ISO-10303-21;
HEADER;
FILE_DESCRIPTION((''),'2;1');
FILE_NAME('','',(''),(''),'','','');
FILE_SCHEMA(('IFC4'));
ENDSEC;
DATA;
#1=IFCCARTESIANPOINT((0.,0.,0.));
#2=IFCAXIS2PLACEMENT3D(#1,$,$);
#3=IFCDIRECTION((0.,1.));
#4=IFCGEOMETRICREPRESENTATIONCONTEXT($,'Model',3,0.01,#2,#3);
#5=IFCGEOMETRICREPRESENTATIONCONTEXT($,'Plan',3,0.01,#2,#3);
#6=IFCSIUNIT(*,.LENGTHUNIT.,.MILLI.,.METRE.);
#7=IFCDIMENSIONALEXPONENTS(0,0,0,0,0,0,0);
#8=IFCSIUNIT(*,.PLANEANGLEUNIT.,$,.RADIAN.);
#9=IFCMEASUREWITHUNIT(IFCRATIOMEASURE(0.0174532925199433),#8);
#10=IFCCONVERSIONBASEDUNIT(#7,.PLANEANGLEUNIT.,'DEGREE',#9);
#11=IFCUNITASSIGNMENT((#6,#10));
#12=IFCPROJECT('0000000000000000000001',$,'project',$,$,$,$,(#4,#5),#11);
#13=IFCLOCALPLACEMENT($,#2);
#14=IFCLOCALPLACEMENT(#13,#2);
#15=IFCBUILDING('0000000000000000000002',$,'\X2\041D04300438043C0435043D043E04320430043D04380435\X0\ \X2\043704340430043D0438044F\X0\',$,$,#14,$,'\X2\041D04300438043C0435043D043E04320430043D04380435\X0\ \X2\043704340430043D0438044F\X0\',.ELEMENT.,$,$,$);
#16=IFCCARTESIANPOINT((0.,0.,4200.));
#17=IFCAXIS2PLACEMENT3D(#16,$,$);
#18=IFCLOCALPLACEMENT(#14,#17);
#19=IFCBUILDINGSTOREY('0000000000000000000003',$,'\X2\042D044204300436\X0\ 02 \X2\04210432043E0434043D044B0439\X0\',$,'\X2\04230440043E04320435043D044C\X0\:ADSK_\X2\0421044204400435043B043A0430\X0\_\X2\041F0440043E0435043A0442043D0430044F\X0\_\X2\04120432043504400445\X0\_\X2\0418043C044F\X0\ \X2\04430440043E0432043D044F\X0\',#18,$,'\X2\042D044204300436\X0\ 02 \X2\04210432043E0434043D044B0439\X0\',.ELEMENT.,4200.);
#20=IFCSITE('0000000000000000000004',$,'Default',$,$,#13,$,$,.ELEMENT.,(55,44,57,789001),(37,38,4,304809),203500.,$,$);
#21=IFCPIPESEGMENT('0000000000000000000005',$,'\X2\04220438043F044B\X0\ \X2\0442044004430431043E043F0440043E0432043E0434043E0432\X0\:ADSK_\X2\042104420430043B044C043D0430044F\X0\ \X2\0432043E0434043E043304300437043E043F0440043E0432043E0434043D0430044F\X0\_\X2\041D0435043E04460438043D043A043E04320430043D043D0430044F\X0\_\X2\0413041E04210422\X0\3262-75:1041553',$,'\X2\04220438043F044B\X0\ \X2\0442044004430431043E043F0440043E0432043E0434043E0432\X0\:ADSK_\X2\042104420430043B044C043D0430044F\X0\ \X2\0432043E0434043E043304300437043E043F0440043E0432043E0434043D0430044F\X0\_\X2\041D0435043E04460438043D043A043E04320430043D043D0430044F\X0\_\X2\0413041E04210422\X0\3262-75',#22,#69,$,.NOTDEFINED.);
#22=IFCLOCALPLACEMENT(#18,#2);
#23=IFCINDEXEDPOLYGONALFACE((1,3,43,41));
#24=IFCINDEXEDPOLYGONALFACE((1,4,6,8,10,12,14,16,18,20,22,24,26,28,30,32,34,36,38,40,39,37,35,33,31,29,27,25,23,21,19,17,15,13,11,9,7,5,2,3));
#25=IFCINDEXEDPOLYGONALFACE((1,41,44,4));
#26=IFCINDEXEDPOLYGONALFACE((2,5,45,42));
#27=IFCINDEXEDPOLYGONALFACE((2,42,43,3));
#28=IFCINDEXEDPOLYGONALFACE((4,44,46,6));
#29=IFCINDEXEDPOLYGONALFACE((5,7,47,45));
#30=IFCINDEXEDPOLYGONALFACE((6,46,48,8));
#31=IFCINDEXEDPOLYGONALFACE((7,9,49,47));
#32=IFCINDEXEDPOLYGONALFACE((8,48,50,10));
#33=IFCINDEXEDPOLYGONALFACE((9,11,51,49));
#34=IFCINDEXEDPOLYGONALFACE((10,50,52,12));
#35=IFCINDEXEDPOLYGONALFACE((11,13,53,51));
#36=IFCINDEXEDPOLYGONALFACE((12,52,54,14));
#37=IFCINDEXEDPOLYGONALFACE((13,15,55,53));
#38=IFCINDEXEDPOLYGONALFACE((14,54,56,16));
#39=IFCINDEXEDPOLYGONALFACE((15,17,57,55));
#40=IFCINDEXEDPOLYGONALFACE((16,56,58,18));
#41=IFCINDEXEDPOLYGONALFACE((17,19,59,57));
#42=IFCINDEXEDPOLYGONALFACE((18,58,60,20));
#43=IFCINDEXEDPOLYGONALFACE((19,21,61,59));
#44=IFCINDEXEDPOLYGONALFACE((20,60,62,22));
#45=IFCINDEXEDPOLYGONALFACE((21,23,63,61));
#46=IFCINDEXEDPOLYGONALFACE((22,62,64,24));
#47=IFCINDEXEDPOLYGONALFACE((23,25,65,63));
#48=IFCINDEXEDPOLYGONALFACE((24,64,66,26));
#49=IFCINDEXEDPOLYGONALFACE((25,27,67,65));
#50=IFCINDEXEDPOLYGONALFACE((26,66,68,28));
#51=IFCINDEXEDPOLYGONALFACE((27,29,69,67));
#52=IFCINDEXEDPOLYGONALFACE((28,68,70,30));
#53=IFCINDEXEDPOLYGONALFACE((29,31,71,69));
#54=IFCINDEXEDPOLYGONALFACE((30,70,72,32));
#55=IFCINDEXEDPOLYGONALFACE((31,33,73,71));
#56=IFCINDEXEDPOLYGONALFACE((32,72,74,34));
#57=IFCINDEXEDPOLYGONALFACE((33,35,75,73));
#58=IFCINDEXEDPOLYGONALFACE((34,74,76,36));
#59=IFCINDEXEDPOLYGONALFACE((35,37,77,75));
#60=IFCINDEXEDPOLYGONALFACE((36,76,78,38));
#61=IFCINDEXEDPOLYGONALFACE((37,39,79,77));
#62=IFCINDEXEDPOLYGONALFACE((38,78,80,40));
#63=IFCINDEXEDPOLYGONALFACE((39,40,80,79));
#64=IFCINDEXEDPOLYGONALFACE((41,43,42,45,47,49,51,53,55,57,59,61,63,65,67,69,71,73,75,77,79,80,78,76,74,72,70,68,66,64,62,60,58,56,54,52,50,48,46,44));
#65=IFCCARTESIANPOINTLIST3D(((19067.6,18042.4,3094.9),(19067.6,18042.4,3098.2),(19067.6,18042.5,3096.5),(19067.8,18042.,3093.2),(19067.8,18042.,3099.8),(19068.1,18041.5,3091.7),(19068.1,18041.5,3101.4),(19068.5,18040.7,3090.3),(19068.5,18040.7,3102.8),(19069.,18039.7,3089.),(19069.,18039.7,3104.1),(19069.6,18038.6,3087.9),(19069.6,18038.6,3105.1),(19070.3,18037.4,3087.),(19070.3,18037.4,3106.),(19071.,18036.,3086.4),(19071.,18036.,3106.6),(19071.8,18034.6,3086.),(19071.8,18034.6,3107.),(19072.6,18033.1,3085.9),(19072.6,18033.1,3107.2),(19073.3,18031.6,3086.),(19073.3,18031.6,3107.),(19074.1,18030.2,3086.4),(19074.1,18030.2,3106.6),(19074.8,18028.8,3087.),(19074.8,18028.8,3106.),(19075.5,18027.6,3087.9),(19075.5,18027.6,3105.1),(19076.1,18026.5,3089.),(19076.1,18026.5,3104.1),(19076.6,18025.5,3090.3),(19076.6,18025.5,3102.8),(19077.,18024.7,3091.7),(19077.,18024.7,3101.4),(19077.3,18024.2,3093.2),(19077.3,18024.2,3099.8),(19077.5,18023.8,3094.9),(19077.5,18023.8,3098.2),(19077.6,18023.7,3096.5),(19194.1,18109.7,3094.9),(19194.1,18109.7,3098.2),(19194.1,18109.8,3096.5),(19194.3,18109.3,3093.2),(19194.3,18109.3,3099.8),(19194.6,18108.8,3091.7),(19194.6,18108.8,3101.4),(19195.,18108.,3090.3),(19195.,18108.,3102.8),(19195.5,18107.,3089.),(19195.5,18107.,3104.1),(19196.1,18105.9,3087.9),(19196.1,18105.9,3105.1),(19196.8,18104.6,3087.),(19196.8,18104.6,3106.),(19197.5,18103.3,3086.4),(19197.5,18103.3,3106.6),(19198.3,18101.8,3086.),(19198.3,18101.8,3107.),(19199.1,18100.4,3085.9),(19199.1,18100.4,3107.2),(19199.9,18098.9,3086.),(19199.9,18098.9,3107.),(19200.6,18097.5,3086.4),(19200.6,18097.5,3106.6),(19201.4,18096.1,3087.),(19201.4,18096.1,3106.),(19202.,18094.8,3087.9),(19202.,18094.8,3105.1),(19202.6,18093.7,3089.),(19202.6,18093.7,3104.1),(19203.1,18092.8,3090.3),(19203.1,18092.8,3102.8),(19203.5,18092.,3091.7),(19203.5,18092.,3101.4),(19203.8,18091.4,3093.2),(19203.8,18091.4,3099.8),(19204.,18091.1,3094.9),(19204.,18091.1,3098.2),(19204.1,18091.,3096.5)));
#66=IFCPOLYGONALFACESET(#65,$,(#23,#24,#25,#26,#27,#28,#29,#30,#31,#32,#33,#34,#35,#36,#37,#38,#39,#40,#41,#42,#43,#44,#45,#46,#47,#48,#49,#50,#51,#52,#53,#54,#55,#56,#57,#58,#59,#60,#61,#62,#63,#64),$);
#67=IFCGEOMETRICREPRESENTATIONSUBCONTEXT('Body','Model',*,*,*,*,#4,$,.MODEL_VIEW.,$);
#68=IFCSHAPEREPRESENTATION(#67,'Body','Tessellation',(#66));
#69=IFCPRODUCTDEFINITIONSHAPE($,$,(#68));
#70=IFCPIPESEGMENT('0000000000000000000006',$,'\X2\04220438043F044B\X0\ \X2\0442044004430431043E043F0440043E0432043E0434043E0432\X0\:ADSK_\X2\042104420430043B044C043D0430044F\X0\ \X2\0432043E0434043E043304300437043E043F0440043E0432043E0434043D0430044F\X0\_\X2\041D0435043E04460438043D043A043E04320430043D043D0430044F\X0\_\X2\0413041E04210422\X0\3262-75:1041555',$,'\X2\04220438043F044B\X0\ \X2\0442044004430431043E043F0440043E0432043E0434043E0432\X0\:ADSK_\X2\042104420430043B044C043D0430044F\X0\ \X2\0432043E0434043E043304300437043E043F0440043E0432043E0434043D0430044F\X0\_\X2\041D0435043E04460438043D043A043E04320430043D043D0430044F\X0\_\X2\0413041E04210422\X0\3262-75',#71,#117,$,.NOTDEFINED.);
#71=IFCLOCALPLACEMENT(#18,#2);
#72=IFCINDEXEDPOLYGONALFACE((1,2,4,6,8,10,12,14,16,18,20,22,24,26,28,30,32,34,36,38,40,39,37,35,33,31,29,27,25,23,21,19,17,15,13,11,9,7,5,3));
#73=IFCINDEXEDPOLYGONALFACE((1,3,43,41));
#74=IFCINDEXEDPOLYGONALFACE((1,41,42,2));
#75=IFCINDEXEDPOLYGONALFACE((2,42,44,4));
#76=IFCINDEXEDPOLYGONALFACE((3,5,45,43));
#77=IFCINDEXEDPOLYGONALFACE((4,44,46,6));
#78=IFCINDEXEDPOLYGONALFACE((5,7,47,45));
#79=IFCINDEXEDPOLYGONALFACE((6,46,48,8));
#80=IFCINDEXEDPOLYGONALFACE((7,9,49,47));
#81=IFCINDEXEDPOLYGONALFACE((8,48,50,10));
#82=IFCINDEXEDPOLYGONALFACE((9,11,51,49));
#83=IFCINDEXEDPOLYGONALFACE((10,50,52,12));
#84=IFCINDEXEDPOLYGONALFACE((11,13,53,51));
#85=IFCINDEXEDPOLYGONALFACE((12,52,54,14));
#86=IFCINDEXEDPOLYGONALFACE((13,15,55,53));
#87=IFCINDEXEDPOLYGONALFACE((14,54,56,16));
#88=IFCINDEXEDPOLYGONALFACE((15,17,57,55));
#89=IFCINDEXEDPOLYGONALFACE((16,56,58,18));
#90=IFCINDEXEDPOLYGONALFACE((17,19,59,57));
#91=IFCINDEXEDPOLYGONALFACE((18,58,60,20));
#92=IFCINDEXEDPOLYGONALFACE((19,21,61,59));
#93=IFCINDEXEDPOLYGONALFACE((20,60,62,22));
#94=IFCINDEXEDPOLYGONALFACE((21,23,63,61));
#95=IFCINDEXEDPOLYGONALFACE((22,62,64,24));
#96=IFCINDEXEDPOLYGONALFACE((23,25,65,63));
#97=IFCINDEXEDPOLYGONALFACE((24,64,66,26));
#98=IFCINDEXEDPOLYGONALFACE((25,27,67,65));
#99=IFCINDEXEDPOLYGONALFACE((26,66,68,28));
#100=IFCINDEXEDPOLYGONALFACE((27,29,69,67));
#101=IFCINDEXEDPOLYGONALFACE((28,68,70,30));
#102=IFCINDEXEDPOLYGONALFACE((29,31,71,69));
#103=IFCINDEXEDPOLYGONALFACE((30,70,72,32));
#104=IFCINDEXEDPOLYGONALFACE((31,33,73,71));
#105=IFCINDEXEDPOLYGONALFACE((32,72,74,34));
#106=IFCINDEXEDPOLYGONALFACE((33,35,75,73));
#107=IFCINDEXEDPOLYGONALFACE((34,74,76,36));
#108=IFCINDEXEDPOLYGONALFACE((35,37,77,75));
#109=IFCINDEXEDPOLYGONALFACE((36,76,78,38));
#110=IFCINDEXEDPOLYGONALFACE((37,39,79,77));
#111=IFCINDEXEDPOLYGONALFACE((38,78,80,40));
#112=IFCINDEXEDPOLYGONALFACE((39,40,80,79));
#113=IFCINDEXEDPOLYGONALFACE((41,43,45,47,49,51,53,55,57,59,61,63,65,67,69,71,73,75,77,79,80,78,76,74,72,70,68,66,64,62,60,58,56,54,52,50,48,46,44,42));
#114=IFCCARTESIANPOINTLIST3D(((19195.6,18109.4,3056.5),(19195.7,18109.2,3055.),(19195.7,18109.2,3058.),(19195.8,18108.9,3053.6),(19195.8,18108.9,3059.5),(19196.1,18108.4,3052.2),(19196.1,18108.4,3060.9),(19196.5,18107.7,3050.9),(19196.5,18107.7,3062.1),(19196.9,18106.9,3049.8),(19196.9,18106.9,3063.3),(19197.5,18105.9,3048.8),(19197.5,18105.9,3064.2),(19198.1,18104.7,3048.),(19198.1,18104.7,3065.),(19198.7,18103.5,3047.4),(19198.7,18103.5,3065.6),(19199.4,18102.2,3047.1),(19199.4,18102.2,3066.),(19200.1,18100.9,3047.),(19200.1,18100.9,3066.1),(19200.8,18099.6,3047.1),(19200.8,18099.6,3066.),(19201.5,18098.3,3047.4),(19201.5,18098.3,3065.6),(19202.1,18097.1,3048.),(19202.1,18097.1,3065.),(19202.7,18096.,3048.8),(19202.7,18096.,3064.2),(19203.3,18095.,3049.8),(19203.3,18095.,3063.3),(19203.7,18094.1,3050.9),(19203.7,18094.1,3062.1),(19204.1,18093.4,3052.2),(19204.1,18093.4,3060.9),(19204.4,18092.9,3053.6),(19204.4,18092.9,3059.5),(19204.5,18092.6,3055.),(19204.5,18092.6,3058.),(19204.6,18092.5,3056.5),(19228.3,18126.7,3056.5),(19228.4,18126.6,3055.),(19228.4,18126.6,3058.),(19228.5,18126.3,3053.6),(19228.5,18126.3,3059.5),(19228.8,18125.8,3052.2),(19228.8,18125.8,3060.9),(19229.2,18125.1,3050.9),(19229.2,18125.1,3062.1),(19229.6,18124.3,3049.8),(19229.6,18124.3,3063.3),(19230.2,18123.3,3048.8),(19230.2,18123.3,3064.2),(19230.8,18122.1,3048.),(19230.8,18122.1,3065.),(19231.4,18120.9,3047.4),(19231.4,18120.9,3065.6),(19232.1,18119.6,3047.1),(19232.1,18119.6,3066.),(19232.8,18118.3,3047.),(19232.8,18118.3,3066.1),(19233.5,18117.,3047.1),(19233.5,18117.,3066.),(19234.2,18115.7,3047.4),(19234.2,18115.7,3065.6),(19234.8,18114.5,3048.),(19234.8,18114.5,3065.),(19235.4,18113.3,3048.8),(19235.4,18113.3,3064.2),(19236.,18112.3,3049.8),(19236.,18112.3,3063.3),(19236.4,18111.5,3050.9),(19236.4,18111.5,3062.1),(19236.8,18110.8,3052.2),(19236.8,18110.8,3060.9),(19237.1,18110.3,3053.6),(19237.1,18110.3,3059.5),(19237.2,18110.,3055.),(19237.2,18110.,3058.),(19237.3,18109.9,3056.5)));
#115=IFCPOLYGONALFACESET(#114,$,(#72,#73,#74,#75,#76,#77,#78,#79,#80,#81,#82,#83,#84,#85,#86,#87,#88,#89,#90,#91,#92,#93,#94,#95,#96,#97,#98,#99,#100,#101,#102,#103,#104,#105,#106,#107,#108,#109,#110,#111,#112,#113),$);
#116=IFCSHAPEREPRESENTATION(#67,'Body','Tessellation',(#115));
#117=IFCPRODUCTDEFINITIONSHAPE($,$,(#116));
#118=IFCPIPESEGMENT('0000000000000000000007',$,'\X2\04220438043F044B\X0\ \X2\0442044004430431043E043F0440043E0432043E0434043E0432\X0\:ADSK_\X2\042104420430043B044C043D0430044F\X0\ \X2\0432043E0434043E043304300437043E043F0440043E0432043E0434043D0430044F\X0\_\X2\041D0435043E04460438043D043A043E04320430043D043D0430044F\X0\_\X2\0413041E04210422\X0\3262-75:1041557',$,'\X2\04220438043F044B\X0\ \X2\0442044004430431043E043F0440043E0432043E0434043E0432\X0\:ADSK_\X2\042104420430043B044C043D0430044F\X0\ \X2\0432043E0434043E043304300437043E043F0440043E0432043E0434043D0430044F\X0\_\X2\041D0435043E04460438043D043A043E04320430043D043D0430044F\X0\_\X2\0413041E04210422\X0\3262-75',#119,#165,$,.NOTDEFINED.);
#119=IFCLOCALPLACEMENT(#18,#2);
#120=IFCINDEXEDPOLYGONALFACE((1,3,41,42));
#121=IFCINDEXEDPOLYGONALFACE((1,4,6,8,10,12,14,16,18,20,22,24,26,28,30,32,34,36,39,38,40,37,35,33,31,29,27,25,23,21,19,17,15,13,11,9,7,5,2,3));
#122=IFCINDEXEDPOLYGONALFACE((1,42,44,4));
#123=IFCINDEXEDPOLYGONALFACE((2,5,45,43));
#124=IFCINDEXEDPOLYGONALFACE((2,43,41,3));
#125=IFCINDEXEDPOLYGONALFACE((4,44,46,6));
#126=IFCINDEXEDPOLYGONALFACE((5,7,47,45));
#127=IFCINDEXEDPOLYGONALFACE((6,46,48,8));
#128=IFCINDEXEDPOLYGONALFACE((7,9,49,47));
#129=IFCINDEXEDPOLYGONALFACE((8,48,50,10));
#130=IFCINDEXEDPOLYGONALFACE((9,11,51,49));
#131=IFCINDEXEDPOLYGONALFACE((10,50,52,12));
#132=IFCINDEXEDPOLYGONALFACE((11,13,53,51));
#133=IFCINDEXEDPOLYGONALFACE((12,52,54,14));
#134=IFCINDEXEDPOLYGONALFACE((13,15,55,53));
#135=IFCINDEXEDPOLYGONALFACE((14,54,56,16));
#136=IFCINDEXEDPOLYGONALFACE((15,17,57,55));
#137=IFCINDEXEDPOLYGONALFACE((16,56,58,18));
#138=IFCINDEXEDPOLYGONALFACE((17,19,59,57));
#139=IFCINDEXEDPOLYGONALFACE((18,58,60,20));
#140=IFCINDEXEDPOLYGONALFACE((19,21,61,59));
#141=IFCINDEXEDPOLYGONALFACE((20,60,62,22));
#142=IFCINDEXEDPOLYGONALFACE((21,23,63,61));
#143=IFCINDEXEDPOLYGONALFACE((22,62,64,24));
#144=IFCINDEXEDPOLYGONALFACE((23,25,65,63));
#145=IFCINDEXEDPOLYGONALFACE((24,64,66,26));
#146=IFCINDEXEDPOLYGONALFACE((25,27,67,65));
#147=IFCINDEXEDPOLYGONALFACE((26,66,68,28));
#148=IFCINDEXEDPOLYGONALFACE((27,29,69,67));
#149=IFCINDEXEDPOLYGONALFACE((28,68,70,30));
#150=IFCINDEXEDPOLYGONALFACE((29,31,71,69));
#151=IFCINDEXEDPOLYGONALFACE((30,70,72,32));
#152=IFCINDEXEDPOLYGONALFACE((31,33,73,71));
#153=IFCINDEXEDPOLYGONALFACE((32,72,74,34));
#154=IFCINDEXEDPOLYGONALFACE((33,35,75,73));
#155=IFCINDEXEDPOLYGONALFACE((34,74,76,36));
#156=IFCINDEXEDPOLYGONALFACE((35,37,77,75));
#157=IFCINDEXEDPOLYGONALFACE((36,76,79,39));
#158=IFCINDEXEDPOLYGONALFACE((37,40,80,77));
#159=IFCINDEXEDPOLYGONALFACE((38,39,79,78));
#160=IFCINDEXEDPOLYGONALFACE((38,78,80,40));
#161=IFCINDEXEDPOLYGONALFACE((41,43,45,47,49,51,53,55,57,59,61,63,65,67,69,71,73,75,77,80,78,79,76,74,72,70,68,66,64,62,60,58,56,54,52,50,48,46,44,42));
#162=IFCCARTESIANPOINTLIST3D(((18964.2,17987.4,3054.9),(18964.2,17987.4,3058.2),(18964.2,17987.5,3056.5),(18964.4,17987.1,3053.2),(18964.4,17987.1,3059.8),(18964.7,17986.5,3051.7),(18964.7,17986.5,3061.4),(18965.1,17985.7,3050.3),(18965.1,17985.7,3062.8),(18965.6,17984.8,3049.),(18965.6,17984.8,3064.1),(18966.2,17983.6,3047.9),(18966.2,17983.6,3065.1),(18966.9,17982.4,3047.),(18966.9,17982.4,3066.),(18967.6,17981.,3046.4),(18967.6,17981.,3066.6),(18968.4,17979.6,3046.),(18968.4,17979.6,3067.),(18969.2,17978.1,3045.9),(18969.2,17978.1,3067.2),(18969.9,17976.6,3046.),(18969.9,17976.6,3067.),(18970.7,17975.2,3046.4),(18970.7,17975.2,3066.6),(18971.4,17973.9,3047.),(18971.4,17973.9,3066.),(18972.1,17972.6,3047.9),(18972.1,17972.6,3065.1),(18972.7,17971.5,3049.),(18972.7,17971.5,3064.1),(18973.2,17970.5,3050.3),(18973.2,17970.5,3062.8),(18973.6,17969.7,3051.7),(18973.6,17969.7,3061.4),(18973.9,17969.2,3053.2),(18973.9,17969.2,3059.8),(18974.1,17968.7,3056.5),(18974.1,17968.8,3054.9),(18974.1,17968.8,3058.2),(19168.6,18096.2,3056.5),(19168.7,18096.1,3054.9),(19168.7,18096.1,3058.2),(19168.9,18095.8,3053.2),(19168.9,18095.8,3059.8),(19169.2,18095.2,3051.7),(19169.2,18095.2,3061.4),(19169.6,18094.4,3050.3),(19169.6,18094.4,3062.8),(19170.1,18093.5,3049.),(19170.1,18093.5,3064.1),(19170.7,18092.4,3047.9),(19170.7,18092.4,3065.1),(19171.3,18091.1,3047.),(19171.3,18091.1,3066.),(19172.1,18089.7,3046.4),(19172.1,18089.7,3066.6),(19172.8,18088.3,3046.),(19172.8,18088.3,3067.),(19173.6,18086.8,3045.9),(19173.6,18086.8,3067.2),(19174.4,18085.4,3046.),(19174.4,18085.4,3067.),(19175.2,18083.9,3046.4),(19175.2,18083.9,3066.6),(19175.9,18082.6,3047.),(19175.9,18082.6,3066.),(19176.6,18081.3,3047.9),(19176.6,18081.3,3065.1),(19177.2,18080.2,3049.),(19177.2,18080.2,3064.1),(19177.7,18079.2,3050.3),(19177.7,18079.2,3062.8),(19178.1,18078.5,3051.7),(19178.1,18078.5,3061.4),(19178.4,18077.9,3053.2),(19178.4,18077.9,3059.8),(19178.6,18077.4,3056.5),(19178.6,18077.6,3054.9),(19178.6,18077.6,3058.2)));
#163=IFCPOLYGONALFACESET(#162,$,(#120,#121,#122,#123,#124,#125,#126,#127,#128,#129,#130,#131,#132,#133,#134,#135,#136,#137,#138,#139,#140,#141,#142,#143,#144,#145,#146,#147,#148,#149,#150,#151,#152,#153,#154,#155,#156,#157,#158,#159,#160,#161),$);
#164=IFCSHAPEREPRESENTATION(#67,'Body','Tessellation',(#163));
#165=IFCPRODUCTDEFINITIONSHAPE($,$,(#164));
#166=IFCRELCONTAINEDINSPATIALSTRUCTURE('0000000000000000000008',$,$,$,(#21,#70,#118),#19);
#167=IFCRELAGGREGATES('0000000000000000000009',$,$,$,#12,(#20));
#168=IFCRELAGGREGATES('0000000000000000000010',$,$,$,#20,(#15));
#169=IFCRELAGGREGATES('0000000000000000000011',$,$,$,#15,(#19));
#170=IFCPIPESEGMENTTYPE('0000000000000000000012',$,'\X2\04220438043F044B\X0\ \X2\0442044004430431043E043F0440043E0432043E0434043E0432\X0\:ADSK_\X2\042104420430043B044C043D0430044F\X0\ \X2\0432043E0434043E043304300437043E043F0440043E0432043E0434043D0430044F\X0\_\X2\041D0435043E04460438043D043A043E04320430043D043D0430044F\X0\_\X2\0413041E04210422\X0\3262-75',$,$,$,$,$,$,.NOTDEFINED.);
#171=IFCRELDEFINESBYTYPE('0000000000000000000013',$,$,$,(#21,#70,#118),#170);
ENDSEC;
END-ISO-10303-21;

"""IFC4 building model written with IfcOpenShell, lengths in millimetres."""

from ifc_helpers import new_model, entity, si_unit, converted_unit, direction, frame, origin, place, context, subcontext, project, spatial, indexed_curve, outline, extrude, type_object, element, save


model = new_model("IFC4")

# Units and contexts
model_context = context("Model", 3, precision=0.01, world=origin(), true_north=direction((0.0, 1.0)))
plan_context = context("Plan", 3, precision=0.01, world=origin(), true_north=direction((0.0, 1.0)))
body_context = subcontext(model_context, "Body", "Model", "MODEL_VIEW")
ifc_project = project(units=[si_unit("LENGTHUNIT", "METRE", prefix="MILLI"), converted_unit("PLANEANGLEUNIT", "DEGREE", entity("IfcRatioMeasure", 0.0174532925199433), si_unit("PLANEANGLEUNIT", "RADIAN"), dimensions=[0, 0, 0, 0, 0, 0, 0])], contexts=[model_context, plan_context])

# Site, building, storey
site_placement = place(None, origin())
site = spatial("IfcSite", under=ifc_project, at=site_placement, Name="Default", CompositionType="ELEMENT", RefLatitude=(55, 44, 57, 789001), RefLongitude=(37, 38, 4, 304809), RefElevation=203500.0)
building_placement = place(site_placement, origin())
building = spatial("IfcBuilding", under=site, at=building_placement, Name="Наименование здания", LongName="Наименование здания", CompositionType="ELEMENT")
storey_placement = place(building_placement, frame((0.0, 0.0, 4200.0)))
storey = spatial("IfcBuildingStorey", under=building, at=storey_placement, Name="Этаж 02 Сводный", ObjectType="Уровень:ADSK_Стрелка_Проектная_Вверх_Имя уровня", LongName="Этаж 02 Сводный", CompositionType="ELEMENT", Elevation=4200.0)

# Pipe segments
pipe_segment_type = type_object("IfcPipeSegmentType", Name="Типы трубопроводов:ADSK_Стальная водогазопроводная_Неоцинкованная_ГОСТ3262-75", PredefinedType="NOTDEFINED")
placement = place(storey_placement, origin())
element("IfcPipeSegment", 1, at=placement, inside=storey, type_object=pipe_segment_type, Name="Типы трубопроводов:ADSK_Стальная водогазопроводная_Неоцинкованная_ГОСТ3262-75:1041553", ObjectType="Типы трубопроводов:ADSK_Стальная водогазопроводная_Неоцинкованная_ГОСТ3262-75", PredefinedType="NOTDEFINED", context=body_context, shape_type="SweptSolid", body=[
    extrude(outline(indexed_curve([(10.6, 0.0), (10.5, 1.7), (10.1, 3.3), (9.5, 4.8), (8.6, 6.3), (7.5, 7.5), (6.3, 8.6), (4.8, 9.5), (3.3, 10.1), (1.7, 10.5), (0.0, 10.6), (-1.7, 10.5), (-3.3, 10.1), (-4.8, 9.5), (-6.3, 8.6), (-7.5, 7.5), (-8.6, 6.3), (-9.5, 4.8), (-10.1, 3.3), (-10.5, 1.7), (-10.6, 0.0), (-10.5, -1.7), (-10.1, -3.3), (-9.5, -4.8), (-8.6, -6.3), (-7.5, -7.5), (-6.3, -8.6), (-4.8, -9.5), (-3.3, -10.1), (-1.7, -10.5), (0.0, -10.6), (1.7, -10.5), (3.3, -10.1), (4.8, -9.5), (6.3, -8.6), (7.5, -7.5), (8.6, -6.3), (9.5, -4.8), (10.1, -3.3), (10.5, -1.7), (10.6, 0.0)], self_intersect=False)), frame((19072.6, 18033.1, 3096.5), z_axis=(0.882948, 0.469472, 0.0), x_axis=(-0.469472, 0.882948, 0.0)), (0.0, 0.0, 1.0), 143.3),
])
element("IfcPipeSegment", 2, at=placement, inside=storey, type_object=pipe_segment_type, Name="Типы трубопроводов:ADSK_Стальная водогазопроводная_Неоцинкованная_ГОСТ3262-75:1041555", ObjectType="Типы трубопроводов:ADSK_Стальная водогазопроводная_Неоцинкованная_ГОСТ3262-75", PredefinedType="NOTDEFINED", context=body_context, shape_type="SweptSolid", body=[
    extrude(outline(indexed_curve([(9.6, 0.0), (9.4, 1.5), (9.1, 3.0), (8.5, 4.3), (7.7, 5.6), (6.8, 6.8), (5.6, 7.7), (4.3, 8.5), (3.0, 9.1), (1.5, 9.4), (0.0, 9.6), (-1.5, 9.4), (-3.0, 9.1), (-4.3, 8.5), (-5.6, 7.7), (-6.8, 6.8), (-7.7, 5.6), (-8.5, 4.3), (-9.1, 3.0), (-9.4, 1.5), (-9.6, 0.0), (-9.4, -1.5), (-9.1, -3.0), (-8.5, -4.3), (-7.7, -5.6), (-6.8, -6.8), (-5.6, -7.7), (-4.3, -8.5), (-3.0, -9.1), (-1.5, -9.4), (0.0, -9.6), (1.5, -9.4), (3.0, -9.1), (4.3, -8.5), (5.6, -7.7), (6.8, -6.8), (7.7, -5.6), (8.5, -4.3), (9.1, -3.0), (9.4, -1.5), (9.6, 0.0)], self_intersect=False)), frame((19200.1, 18100.9, 3056.5), z_axis=(0.882948, 0.469472, 0.0), x_axis=(-0.469472, 0.882948, 0.0)), (0.0, 0.0, 1.0), 37.0),
])
element("IfcPipeSegment", 3, at=placement, inside=storey, type_object=pipe_segment_type, Name="Типы трубопроводов:ADSK_Стальная водогазопроводная_Неоцинкованная_ГОСТ3262-75:1041557", ObjectType="Типы трубопроводов:ADSK_Стальная водогазопроводная_Неоцинкованная_ГОСТ3262-75", PredefinedType="NOTDEFINED", context=body_context, shape_type="SweptSolid", body=[
    extrude(outline(indexed_curve([(10.6, 0.0), (10.5, 1.7), (10.1, 3.3), (9.5, 4.8), (8.6, 6.3), (7.5, 7.5), (6.3, 8.6), (4.8, 9.5), (3.3, 10.1), (1.7, 10.5), (0.0, 10.6), (-1.7, 10.5), (-3.3, 10.1), (-4.8, 9.5), (-6.3, 8.6), (-7.5, 7.5), (-8.6, 6.3), (-9.5, 4.8), (-10.1, 3.3), (-10.5, 1.7), (-10.6, 0.0), (-10.5, -1.7), (-10.1, -3.3), (-9.5, -4.8), (-8.6, -6.3), (-7.5, -7.5), (-6.3, -8.6), (-4.8, -9.5), (-3.3, -10.1), (-1.7, -10.5), (0.0, -10.6), (1.7, -10.5), (3.3, -10.1), (4.8, -9.5), (6.3, -8.6), (7.5, -7.5), (8.6, -6.3), (9.5, -4.8), (10.1, -3.3), (10.5, -1.7), (10.6, 0.0)], self_intersect=False)), frame((18969.2, 17978.1, 3056.5), z_axis=(0.882948, 0.469472, 0.0), x_axis=(0.469472, -0.882948, 0.0)), (0.0, 0.0, 1.0), 231.6),
])

save(model, "model.ifc")
